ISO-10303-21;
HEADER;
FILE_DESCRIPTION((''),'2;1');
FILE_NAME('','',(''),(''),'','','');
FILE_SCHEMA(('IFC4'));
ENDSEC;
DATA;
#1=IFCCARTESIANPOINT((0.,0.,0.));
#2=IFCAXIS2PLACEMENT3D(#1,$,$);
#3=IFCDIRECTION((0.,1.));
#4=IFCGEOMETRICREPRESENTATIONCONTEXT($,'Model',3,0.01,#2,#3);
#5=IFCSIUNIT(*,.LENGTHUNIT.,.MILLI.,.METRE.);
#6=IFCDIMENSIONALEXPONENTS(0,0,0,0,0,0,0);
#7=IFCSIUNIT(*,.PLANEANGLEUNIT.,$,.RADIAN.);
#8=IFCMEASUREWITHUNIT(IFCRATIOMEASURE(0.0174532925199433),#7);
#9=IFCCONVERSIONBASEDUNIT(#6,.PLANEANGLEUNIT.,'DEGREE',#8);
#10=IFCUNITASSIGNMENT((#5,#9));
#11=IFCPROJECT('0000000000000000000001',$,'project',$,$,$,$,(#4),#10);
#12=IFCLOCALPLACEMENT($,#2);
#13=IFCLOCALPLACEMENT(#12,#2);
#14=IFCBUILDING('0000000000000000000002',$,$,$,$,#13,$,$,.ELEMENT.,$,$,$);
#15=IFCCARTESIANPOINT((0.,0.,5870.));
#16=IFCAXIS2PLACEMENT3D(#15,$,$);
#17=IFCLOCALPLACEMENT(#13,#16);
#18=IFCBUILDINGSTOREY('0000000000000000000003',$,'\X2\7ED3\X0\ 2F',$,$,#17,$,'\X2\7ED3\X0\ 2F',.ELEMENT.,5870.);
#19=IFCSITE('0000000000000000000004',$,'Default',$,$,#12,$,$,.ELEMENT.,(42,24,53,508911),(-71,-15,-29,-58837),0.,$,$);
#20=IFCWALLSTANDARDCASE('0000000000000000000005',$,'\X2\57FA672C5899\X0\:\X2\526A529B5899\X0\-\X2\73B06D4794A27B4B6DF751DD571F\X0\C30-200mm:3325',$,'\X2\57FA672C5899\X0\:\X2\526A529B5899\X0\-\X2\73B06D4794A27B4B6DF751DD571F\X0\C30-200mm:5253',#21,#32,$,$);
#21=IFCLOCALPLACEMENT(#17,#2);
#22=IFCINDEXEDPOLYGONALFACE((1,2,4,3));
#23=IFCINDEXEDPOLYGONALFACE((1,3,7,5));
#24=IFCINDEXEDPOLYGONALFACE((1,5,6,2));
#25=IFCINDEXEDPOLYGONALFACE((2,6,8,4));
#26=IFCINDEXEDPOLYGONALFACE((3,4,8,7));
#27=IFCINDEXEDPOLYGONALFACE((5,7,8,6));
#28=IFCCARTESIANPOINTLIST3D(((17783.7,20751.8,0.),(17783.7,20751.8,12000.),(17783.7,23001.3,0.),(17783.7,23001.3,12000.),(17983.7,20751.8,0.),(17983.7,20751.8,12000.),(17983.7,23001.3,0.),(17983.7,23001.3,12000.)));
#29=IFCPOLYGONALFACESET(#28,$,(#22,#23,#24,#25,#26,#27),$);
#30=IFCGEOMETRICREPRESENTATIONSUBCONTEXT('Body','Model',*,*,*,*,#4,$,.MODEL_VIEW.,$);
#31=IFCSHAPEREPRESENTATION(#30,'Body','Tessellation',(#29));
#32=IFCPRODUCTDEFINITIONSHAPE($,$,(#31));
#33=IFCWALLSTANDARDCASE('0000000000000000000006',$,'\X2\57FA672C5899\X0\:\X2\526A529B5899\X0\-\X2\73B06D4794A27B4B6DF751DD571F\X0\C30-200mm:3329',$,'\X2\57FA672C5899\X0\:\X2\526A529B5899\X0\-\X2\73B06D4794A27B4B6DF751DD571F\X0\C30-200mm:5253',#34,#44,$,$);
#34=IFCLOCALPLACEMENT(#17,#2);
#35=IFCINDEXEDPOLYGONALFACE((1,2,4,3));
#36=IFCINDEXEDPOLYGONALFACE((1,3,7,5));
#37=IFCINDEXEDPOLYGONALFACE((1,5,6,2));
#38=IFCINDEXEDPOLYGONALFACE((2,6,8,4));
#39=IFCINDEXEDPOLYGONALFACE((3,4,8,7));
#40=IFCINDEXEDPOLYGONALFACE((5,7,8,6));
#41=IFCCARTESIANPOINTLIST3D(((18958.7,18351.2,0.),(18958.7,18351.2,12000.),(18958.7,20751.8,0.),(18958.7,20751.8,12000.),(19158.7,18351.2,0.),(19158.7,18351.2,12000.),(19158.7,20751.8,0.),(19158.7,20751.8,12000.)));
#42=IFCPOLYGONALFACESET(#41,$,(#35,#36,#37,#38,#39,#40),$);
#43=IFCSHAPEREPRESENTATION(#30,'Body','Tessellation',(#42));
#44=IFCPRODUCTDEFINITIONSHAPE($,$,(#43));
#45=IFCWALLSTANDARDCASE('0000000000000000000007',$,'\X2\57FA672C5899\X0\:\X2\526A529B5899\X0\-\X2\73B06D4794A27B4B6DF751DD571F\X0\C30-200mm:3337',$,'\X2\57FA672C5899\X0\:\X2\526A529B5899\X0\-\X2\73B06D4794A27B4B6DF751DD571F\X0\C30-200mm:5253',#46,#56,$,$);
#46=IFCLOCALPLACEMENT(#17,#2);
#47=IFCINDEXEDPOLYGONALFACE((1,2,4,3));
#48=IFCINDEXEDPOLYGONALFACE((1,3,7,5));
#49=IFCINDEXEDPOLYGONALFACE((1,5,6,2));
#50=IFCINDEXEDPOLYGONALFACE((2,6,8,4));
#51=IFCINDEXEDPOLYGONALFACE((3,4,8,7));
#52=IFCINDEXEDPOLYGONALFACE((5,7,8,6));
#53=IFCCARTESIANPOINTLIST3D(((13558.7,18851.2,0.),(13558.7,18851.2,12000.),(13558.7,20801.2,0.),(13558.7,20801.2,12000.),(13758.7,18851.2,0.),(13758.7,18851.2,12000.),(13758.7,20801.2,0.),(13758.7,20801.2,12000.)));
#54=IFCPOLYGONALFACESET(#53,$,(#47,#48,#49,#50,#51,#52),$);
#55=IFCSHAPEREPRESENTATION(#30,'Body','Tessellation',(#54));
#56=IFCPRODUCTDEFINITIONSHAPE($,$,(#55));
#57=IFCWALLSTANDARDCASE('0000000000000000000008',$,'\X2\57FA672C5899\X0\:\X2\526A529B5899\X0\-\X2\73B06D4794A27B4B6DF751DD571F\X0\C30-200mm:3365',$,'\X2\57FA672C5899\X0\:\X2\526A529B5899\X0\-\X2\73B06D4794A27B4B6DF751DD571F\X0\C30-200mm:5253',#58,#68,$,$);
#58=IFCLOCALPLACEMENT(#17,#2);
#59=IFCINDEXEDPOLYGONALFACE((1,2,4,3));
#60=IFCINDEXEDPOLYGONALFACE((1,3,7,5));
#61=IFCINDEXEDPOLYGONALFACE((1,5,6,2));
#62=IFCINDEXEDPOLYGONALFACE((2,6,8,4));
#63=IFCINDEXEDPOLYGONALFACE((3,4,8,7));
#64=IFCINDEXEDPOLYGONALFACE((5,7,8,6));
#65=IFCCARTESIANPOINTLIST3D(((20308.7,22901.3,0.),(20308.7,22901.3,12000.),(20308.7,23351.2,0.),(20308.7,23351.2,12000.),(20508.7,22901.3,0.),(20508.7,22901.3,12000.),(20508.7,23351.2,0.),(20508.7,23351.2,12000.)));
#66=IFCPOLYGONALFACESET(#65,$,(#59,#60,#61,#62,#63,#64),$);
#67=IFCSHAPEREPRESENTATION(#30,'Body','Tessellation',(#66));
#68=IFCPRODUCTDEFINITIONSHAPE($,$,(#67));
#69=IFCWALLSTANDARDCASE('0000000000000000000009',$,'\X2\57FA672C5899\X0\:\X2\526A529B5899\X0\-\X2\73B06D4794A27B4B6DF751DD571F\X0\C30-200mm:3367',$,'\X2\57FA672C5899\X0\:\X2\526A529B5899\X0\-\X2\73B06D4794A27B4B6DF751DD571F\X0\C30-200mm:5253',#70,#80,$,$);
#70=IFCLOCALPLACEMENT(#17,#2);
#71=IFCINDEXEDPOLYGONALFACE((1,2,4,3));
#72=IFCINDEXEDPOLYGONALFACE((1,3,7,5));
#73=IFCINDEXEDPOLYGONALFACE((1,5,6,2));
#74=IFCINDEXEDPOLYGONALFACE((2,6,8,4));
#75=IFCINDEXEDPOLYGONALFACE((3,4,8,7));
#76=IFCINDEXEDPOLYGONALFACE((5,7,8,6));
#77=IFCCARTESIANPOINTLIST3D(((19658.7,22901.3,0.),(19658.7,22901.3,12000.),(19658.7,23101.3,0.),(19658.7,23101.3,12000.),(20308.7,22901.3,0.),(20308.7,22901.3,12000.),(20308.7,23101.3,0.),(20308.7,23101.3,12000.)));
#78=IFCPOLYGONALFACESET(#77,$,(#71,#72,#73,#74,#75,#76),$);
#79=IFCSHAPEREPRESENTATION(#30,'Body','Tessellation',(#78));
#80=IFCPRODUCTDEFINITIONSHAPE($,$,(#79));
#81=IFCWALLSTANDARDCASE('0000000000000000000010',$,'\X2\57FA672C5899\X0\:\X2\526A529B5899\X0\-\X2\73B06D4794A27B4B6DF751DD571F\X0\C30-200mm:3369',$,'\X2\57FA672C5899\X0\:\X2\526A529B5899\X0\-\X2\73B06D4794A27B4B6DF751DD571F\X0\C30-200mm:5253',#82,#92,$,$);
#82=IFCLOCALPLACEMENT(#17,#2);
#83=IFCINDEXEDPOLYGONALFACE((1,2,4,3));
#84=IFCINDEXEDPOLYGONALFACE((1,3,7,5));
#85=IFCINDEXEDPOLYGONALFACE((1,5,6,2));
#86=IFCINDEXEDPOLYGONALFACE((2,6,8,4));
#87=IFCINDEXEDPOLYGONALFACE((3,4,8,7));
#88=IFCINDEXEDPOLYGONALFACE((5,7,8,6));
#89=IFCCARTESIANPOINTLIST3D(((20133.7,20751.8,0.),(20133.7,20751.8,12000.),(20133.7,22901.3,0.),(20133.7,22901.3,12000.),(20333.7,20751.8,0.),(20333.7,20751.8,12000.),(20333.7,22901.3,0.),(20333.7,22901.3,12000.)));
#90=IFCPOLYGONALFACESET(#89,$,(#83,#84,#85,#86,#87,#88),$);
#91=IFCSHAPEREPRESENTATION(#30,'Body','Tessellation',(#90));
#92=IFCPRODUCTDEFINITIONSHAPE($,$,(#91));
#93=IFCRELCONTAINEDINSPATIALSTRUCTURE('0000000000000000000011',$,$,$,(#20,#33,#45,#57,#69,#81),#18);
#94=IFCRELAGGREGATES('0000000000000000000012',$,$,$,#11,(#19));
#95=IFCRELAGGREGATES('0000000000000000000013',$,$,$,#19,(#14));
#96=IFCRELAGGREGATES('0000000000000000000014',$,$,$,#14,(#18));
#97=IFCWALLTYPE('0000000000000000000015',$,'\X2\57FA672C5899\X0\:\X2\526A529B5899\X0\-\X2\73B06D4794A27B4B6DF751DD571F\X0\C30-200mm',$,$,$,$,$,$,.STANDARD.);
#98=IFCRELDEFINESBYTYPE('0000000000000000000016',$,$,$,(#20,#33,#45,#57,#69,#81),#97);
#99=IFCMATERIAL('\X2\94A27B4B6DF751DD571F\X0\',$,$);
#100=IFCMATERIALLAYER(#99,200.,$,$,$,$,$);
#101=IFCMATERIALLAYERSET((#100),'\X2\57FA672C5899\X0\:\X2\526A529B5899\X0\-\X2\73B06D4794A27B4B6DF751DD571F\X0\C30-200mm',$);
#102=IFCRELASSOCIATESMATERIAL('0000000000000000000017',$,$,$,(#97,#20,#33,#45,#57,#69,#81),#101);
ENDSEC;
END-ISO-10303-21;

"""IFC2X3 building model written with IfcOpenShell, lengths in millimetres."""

from ifc_helpers import new_model, entity, si_unit, converted_unit, direction, frame, frame_2d, origin, place, context, subcontext, project, spatial, rectangle, extrude, material, layer, layer_set, layer_usage, type_object, element, save


model = new_model("IFC2X3")

# Units and contexts
model_context = context("Model", 3, precision=0.01, world=origin(), true_north=direction((0.0, 1.0)))
body_context = subcontext(model_context, "Body", "Model", "MODEL_VIEW")
ifc_project = project(units=[si_unit("LENGTHUNIT", "METRE", prefix="MILLI"), converted_unit("PLANEANGLEUNIT", "DEGREE", entity("IfcRatioMeasure", 0.0174532925199433), si_unit("PLANEANGLEUNIT", "RADIAN"), dimensions=[0, 0, 0, 0, 0, 0, 0])], contexts=[model_context])

# Site, building, storey
site_placement = place(None, origin())
site = spatial("IfcSite", under=ifc_project, at=site_placement, Name="Default", CompositionType="ELEMENT", RefLatitude=(42, 24, 53, 508911), RefLongitude=(-71, -15, -29, -58837), RefElevation=0.0)
building_placement = place(site_placement, origin())
building = spatial("IfcBuilding", under=site, at=building_placement, CompositionType="ELEMENT")
storey_placement = place(building_placement, frame((0.0, 0.0, 5870.0)))
storey = spatial("IfcBuildingStorey", under=building, at=storey_placement, Name="结 2F", LongName="结 2F", CompositionType="ELEMENT", Elevation=5870.0)

# Shared definitions
ifc_material = material(Name="钢筋混凝土")

# Walls
ifc_layer = layer(ifc_material, 200.0)
ifc_layer_set = layer_set([ifc_layer], Name="基本墙:剪力墙-现浇钢筋混凝土C30-200mm")
wall_type = type_object("IfcWallType", Name="基本墙:剪力墙-现浇钢筋混凝土C30-200mm", PredefinedType="STANDARD", material=ifc_layer_set)
ifc_layer_usage_1 = layer_usage(ifc_layer_set, "AXIS2", "NEGATIVE", 100.0)
wall_1_placement = place(storey_placement, frame((17883.7, 23001.3, 0.0), z_axis=(0.0, 0.0, 1.0), x_axis=(0.0, -1.0, 0.0)))
element("IfcWallStandardCase", 1, at=wall_1_placement, inside=storey, type_object=wall_type, material=ifc_layer_usage_1, Name="基本墙:剪力墙-现浇钢筋混凝土C30-200mm:3325", ObjectType="基本墙:剪力墙-现浇钢筋混凝土C30-200mm:5253", context=body_context, shape_type="SweptSolid", body=[
    extrude(rectangle(XDim=2249.5, YDim=200.0, at=frame_2d((1124.7, 0.0), x_axis=(-1.0, 0.0))), origin(), (0.0, 0.0, 1.0), 12000.0),
])
ifc_layer_usage_2 = layer_usage(ifc_layer_set, "AXIS2", "NEGATIVE", 100.0)
wall_2_placement = place(storey_placement, frame((19058.7, 20751.8, 0.0), z_axis=(0.0, 0.0, 1.0), x_axis=(0.0, -1.0, 0.0)))
element("IfcWallStandardCase", 2, at=wall_2_placement, inside=storey, type_object=wall_type, material=ifc_layer_usage_2, Name="基本墙:剪力墙-现浇钢筋混凝土C30-200mm:3329", ObjectType="基本墙:剪力墙-现浇钢筋混凝土C30-200mm:5253", context=body_context, shape_type="SweptSolid", body=[
    extrude(rectangle(XDim=2400.6, YDim=200.0, at=frame_2d((1200.3, 0.0), x_axis=(-1.0, 0.0))), origin(), (0.0, 0.0, 1.0), 12000.0),
])
ifc_layer_usage_3 = layer_usage(ifc_layer_set, "AXIS2", "NEGATIVE", 100.0)
wall_3_placement = place(storey_placement, frame((13658.7, 20801.2, 0.0), z_axis=(0.0, 0.0, 1.0), x_axis=(0.0, -1.0, 0.0)))
element("IfcWallStandardCase", 3, at=wall_3_placement, inside=storey, type_object=wall_type, material=ifc_layer_usage_3, Name="基本墙:剪力墙-现浇钢筋混凝土C30-200mm:3337", ObjectType="基本墙:剪力墙-现浇钢筋混凝土C30-200mm:5253", context=body_context, shape_type="SweptSolid", body=[
    extrude(rectangle(XDim=1950.0, YDim=200.0, at=frame_2d((975.0, 0.0), x_axis=(-1.0, 0.0))), origin(), (0.0, 0.0, 1.0), 12000.0),
])
ifc_layer_usage_4 = layer_usage(ifc_layer_set, "AXIS2", "POSITIVE", -100.0)
wall_4_placement = place(storey_placement, frame((20408.7, 23351.2, 0.0), z_axis=(0.0, 0.0, 1.0), x_axis=(0.0, -1.0, 0.0)))
element("IfcWallStandardCase", 4, at=wall_4_placement, inside=storey, type_object=wall_type, material=ifc_layer_usage_4, Name="基本墙:剪力墙-现浇钢筋混凝土C30-200mm:3365", ObjectType="基本墙:剪力墙-现浇钢筋混凝土C30-200mm:5253", context=body_context, shape_type="SweptSolid", body=[
    extrude(rectangle(XDim=449.9, YDim=200.0, at=frame_2d((225.0, 0.0), x_axis=(-1.0, 0.0))), origin(), (0.0, 0.0, 1.0), 12000.0),
])
ifc_layer_usage_5 = layer_usage(ifc_layer_set, "AXIS2", "POSITIVE", -100.0)
wall_5_placement = place(storey_placement, frame((20308.7, 23001.3, 0.0), z_axis=(0.0, 0.0, 1.0), x_axis=(-1.0, 0.0, 0.0)))
element("IfcWallStandardCase", 5, at=wall_5_placement, inside=storey, type_object=wall_type, material=ifc_layer_usage_5, Name="基本墙:剪力墙-现浇钢筋混凝土C30-200mm:3367", ObjectType="基本墙:剪力墙-现浇钢筋混凝土C30-200mm:5253", context=body_context, shape_type="SweptSolid", body=[
    extrude(rectangle(XDim=650.0, YDim=200.0, at=frame_2d((325.0, 0.0), x_axis=(-1.0, 0.0))), origin(), (0.0, 0.0, 1.0), 12000.0),
])
ifc_layer_usage_6 = layer_usage(ifc_layer_set, "AXIS2", "POSITIVE", -100.0)
wall_6_placement = place(storey_placement, frame((20233.7, 22901.3, 0.0), z_axis=(0.0, 0.0, 1.0), x_axis=(0.0, -1.0, 0.0)))
element("IfcWallStandardCase", 6, at=wall_6_placement, inside=storey, type_object=wall_type, material=ifc_layer_usage_6, Name="基本墙:剪力墙-现浇钢筋混凝土C30-200mm:3369", ObjectType="基本墙:剪力墙-现浇钢筋混凝土C30-200mm:5253", context=body_context, shape_type="SweptSolid", body=[
    extrude(rectangle(XDim=2149.5, YDim=200.0, at=frame_2d((1074.7, 0.0), x_axis=(-1.0, 0.0))), origin(), (0.0, 0.0, 1.0), 12000.0),
])

save(model, "model.ifc")
